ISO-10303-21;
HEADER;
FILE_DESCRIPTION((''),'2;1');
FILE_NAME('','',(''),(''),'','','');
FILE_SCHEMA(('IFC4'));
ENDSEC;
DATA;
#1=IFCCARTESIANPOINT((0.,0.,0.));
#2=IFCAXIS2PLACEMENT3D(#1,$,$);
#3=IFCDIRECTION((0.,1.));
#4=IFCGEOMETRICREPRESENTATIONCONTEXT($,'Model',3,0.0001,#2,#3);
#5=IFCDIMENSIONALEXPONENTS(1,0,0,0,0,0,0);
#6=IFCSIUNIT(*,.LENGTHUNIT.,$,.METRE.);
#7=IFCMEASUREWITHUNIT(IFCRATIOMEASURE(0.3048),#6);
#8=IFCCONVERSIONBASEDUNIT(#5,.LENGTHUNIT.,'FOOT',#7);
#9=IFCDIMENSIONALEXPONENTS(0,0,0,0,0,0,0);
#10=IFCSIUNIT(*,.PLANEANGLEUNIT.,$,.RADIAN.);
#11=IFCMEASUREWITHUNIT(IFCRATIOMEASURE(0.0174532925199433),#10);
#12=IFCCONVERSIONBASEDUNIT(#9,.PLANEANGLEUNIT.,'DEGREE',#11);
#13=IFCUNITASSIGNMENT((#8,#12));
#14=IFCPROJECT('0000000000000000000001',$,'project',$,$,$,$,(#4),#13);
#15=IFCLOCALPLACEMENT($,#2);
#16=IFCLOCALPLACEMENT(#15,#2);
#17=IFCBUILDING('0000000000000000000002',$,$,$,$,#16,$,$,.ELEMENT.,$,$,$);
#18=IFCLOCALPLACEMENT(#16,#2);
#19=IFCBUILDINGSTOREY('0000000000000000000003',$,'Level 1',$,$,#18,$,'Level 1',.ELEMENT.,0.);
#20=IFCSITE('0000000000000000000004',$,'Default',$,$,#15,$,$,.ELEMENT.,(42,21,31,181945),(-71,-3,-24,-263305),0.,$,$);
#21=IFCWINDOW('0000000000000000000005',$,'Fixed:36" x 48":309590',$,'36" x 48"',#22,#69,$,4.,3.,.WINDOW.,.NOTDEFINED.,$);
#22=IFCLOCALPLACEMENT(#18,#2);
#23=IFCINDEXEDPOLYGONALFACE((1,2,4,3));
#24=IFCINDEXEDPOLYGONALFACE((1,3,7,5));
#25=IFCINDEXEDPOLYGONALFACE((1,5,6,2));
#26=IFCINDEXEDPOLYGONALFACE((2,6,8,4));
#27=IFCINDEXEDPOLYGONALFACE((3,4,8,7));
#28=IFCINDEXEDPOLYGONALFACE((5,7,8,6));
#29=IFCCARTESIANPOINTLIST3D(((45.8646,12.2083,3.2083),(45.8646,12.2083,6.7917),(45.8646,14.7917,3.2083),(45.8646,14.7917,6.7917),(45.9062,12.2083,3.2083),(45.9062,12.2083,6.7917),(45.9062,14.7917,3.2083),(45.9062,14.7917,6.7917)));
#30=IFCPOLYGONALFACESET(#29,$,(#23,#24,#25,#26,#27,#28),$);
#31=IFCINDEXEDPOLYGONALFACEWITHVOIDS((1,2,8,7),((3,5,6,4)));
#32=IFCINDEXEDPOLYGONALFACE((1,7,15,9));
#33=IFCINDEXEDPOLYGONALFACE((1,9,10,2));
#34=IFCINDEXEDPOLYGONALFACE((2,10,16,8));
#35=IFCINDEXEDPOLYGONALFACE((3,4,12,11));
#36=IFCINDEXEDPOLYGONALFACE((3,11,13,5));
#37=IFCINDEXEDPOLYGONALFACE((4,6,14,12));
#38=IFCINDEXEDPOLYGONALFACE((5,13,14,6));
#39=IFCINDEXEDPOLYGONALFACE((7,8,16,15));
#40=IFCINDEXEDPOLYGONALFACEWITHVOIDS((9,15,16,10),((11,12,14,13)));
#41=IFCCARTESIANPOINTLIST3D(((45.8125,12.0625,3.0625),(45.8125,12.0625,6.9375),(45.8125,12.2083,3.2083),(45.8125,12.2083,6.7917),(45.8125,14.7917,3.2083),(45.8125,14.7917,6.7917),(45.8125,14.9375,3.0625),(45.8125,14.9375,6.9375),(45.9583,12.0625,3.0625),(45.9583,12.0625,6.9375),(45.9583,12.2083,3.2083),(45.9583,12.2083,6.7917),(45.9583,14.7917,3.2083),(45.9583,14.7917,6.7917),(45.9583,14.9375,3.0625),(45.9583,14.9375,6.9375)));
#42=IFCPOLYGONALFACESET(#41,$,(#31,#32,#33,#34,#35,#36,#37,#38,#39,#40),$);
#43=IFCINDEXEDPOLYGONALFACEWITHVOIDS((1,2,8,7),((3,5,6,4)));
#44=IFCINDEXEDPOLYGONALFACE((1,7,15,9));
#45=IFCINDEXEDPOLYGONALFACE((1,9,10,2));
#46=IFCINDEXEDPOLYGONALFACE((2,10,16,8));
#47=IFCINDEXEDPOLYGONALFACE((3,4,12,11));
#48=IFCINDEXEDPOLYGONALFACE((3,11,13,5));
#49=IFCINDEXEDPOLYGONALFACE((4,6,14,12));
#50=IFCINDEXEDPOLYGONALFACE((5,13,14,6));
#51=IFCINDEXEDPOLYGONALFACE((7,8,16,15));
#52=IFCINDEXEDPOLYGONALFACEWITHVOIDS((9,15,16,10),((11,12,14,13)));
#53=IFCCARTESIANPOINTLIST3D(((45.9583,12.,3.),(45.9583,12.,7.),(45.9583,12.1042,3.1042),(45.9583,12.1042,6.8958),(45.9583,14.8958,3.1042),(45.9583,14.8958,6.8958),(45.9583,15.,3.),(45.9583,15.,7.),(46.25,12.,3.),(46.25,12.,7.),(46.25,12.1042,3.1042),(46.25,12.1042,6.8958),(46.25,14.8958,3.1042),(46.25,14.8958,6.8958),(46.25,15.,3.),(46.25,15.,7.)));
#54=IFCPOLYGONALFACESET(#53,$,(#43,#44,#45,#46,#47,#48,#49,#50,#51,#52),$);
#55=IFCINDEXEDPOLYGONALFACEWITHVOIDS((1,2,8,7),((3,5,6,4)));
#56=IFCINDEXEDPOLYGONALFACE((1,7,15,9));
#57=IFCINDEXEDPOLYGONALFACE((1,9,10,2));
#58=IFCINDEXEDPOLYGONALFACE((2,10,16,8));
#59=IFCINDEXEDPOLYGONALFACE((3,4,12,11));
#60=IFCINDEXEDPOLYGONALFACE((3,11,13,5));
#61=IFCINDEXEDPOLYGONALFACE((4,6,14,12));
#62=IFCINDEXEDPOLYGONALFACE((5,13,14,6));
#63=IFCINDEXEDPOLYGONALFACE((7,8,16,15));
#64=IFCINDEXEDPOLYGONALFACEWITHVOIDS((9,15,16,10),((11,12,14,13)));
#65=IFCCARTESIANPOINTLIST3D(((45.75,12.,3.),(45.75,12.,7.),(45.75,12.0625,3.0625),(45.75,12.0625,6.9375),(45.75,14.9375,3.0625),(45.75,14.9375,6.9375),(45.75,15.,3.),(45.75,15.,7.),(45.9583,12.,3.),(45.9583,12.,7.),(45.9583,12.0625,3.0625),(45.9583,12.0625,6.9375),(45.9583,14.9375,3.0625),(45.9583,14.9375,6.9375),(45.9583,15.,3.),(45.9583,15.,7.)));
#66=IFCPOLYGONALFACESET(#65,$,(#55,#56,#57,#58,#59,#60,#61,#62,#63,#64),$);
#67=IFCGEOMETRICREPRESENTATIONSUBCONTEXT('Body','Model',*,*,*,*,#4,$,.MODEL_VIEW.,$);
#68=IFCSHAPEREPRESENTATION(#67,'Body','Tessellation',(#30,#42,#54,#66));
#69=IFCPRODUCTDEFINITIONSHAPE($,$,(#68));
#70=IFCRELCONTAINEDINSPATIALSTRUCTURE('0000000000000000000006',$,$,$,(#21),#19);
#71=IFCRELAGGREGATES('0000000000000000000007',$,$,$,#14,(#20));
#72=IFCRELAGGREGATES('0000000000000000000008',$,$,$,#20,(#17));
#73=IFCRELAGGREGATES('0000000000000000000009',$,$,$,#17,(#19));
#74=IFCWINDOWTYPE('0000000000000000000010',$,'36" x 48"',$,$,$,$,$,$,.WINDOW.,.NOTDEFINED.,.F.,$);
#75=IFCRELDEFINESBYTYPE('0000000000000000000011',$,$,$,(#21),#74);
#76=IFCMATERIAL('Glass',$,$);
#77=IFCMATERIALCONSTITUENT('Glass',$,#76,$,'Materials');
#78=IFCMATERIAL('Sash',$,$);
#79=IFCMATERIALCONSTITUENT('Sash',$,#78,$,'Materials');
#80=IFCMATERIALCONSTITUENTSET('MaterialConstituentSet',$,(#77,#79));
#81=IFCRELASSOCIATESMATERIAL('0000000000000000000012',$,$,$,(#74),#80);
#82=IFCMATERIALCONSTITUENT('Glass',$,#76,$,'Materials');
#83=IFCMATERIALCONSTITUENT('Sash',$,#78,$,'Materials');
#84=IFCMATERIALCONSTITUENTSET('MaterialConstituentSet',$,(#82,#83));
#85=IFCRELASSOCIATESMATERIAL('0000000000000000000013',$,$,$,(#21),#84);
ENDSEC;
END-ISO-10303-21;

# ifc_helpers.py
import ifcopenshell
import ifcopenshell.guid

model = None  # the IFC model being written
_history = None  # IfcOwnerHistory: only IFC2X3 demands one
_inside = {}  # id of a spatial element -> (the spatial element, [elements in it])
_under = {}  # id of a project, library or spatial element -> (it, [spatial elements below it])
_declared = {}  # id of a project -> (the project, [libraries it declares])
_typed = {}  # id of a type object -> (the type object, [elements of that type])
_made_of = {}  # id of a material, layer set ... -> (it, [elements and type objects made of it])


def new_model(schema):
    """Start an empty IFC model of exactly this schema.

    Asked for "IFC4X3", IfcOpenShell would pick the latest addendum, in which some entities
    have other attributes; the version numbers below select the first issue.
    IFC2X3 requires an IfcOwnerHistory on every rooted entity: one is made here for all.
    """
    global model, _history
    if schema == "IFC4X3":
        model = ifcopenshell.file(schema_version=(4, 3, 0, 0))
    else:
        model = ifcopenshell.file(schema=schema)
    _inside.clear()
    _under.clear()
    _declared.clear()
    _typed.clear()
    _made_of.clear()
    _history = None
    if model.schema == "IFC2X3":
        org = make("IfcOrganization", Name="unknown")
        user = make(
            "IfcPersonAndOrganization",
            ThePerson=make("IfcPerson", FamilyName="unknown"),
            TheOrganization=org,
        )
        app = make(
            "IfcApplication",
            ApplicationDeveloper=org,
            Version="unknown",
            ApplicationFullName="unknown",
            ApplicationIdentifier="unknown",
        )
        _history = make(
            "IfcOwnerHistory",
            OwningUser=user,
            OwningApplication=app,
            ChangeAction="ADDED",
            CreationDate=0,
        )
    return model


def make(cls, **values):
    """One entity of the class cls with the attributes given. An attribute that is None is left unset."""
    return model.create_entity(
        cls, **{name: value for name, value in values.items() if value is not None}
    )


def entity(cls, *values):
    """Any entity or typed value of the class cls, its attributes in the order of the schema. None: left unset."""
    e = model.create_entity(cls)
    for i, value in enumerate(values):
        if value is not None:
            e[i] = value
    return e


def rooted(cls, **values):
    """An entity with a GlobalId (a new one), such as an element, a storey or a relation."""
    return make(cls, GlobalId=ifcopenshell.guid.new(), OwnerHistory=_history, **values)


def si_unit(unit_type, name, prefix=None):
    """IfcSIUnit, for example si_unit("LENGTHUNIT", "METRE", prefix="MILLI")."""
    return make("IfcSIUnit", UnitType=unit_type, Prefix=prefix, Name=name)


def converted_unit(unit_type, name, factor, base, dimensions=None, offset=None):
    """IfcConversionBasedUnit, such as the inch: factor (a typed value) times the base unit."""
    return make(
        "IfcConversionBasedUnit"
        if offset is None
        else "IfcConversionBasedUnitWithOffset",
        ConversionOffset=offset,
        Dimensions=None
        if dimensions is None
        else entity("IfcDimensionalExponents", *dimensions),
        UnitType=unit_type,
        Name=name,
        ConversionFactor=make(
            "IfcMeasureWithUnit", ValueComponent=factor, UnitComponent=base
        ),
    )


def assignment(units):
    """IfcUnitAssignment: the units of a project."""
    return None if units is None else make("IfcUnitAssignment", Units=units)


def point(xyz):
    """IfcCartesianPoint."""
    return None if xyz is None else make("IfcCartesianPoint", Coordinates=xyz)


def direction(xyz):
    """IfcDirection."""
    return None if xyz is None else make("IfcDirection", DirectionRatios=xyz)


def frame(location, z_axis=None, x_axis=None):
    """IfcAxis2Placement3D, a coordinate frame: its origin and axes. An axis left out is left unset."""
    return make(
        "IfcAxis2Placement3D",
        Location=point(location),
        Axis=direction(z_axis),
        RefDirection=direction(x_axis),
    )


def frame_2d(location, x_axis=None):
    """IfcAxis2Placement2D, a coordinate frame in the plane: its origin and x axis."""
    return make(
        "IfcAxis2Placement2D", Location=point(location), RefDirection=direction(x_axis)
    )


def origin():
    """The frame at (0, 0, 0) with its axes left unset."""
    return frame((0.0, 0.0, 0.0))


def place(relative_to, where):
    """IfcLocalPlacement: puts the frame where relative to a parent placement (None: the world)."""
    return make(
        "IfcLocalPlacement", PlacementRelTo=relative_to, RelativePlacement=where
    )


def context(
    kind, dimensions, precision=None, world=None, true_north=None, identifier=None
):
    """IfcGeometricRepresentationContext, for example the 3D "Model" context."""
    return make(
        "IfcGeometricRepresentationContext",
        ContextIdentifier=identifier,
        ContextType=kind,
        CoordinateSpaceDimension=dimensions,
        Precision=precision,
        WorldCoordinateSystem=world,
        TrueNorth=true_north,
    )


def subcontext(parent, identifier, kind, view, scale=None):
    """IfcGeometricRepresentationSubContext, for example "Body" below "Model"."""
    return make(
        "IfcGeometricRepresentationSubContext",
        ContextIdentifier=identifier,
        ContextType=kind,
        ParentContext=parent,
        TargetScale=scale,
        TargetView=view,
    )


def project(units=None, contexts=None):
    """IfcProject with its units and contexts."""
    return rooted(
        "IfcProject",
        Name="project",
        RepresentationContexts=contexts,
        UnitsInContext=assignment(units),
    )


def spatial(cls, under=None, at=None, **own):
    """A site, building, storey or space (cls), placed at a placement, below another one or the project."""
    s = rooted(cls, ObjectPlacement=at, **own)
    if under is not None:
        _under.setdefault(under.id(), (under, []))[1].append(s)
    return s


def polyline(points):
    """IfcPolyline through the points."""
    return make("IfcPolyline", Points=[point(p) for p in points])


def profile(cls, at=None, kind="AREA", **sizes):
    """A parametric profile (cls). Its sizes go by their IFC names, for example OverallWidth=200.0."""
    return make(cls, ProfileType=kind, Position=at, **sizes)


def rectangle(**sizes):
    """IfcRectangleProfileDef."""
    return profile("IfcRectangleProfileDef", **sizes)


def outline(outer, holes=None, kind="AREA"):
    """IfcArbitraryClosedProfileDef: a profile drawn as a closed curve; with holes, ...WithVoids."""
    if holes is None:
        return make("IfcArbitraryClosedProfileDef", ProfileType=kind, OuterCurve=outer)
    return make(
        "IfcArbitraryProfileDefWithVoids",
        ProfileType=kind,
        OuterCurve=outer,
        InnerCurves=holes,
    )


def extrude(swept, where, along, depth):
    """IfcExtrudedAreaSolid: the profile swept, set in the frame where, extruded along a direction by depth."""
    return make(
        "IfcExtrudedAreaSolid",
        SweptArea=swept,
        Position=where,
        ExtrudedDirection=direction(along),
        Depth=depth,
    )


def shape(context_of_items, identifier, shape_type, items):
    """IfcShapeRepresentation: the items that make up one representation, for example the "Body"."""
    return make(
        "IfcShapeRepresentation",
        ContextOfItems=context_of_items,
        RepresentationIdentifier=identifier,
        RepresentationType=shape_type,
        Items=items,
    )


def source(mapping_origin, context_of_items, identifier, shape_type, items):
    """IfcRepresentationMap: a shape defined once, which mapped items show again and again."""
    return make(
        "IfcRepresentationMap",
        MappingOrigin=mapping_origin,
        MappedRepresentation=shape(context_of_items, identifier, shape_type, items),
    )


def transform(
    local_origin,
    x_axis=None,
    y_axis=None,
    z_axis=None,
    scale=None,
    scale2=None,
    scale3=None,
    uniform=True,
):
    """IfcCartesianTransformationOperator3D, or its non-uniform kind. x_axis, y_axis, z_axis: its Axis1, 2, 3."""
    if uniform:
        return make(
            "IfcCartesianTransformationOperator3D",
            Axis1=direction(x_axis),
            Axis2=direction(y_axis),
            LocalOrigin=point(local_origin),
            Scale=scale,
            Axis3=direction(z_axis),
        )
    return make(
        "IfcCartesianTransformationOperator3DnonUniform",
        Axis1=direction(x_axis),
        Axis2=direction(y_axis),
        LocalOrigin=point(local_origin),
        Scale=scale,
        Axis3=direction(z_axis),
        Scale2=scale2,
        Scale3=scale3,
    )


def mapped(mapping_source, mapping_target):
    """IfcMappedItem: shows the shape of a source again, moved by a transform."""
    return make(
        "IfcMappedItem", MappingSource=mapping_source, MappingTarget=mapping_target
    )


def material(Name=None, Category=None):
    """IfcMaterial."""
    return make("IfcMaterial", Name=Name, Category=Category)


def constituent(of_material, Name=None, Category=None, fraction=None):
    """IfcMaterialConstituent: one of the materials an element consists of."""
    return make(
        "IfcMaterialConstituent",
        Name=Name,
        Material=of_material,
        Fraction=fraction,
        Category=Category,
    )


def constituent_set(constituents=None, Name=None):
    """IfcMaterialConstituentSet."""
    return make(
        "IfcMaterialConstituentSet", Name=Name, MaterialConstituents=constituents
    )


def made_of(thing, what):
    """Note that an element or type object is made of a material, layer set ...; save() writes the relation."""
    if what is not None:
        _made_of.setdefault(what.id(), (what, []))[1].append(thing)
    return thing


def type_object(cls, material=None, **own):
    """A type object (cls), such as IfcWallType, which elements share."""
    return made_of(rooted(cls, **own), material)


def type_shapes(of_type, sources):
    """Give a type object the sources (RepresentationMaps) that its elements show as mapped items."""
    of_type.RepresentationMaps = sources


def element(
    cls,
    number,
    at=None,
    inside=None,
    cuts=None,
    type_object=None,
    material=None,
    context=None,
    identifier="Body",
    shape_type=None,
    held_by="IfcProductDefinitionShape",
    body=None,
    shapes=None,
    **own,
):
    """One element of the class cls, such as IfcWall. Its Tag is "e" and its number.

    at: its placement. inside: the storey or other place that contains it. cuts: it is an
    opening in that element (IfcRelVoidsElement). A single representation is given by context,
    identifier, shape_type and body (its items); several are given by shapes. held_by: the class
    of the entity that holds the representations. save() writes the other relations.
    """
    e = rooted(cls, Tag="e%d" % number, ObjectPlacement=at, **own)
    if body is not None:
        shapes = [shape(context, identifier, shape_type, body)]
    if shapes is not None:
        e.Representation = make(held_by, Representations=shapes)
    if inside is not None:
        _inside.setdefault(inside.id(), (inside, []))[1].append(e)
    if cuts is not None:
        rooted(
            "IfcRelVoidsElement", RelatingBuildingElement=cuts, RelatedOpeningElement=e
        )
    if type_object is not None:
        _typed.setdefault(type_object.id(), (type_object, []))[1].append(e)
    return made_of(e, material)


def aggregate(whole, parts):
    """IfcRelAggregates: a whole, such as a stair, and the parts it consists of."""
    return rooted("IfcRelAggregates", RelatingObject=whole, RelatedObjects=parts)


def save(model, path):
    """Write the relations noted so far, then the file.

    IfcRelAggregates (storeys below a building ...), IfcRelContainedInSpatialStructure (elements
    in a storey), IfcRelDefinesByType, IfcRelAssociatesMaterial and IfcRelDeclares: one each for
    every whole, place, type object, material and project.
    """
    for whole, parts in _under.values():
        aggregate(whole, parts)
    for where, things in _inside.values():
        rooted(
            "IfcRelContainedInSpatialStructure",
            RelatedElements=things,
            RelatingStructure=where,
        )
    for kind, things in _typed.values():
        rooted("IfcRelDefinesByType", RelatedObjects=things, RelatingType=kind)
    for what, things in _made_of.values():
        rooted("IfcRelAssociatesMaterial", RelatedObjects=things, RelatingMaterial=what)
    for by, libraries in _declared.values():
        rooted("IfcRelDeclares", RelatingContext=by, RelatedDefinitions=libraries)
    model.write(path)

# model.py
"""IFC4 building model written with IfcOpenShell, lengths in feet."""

from ifc_helpers import new_model, entity, si_unit, converted_unit, direction, frame, frame_2d, origin, place, context, subcontext, project, spatial, polyline, rectangle, outline, extrude, source, transform, mapped, material, constituent, constituent_set, type_object, type_shapes, element, save


model = new_model("IFC4")

# Units and contexts
model_context = context("Model", 3, precision=0.0001, world=origin(), true_north=direction((0.0, 1.0)))
body_context = subcontext(model_context, "Body", "Model", "MODEL_VIEW")
ifc_project = project(units=[converted_unit("LENGTHUNIT", "FOOT", entity("IfcRatioMeasure", 0.3048), si_unit("LENGTHUNIT", "METRE"), dimensions=[1, 0, 0, 0, 0, 0, 0]), converted_unit("PLANEANGLEUNIT", "DEGREE", entity("IfcRatioMeasure", 0.0174532925199433), si_unit("PLANEANGLEUNIT", "RADIAN"), dimensions=[0, 0, 0, 0, 0, 0, 0])], contexts=[model_context])

# Site, building, storey
site_placement = place(None, origin())
site = spatial("IfcSite", under=ifc_project, at=site_placement, Name="Default", CompositionType="ELEMENT", RefLatitude=(42, 21, 31, 181945), RefLongitude=(-71, -3, -24, -263305), RefElevation=0.0)
building_placement = place(site_placement, origin())
building = spatial("IfcBuilding", under=site, at=building_placement, CompositionType="ELEMENT")
storey_placement = place(building_placement, origin())
storey = spatial("IfcBuildingStorey", under=building, at=storey_placement, Name="Level 1", LongName="Level 1", CompositionType="ELEMENT", Elevation=0.0)

# Shared definitions
placement_1 = place(storey_placement, frame((46.0, 46.25, 0.0), z_axis=(0.0, 0.0, 1.0), x_axis=(0.0, -1.0, 0.0)))

# Window
ifc_material_1 = material(Name="Glass")
ifc_constituent_1 = constituent(ifc_material_1, Name="Glass", Category="Materials")
ifc_material_2 = material(Name="Sash")
ifc_constituent_2 = constituent(ifc_material_2, Name="Sash", Category="Materials")
ifc_constituent_set_1 = constituent_set(constituents=[ifc_constituent_1, ifc_constituent_2], Name="MaterialConstituentSet")
ifc_constituent_3 = constituent(ifc_material_1, Name="Glass", Category="Materials")
ifc_constituent_4 = constituent(ifc_material_2, Name="Sash", Category="Materials")
ifc_constituent_set_2 = constituent_set(constituents=[ifc_constituent_3, ifc_constituent_4], Name="MaterialConstituentSet")
window_type = type_object("IfcWindowType", Name="36\" x 48\"", ParameterTakesPrecedence=False, PartitioningType="NOTDEFINED", PredefinedType="WINDOW", material=ifc_constituent_set_2)
shared_shape = source(origin(), body_context, "Body", "SweptSolid", [
    extrude(rectangle(XDim=0.0417, YDim=2.5833, at=frame_2d((0.0, 0.0), x_axis=(1.0, 0.0))), frame((1.5, 0.3646, 0.2083), z_axis=(0.0, 0.0, 1.0), x_axis=(0.0, 1.0, 0.0)), (0.0, 0.0, 1.0), 3.5833),
    extrude(outline(polyline([(-1.4375, -1.9375), (1.4375, -1.9375), (1.4375, 1.9375), (-1.4375, 1.9375), (-1.4375, -1.9375)]), holes=[polyline([(-1.2917, -1.7917), (-1.2917, 1.7917), (1.2917, 1.7917), (1.2917, -1.7917), (-1.2917, -1.7917)])]), frame((1.5, 0.2917, 2.0), z_axis=(0.0, 1.0, 0.0), x_axis=(1.0, 0.0, 0.0)), (0.0, 0.0, 1.0), 0.1458),
    extrude(outline(polyline([(-1.5, -2.0), (1.5, -2.0), (1.5, 2.0), (-1.5, 2.0), (-1.5, -2.0)]), holes=[polyline([(-1.3958, -1.8958), (-1.3958, 1.8958), (1.3958, 1.8958), (1.3958, -1.8958), (-1.3958, -1.8958)])]), frame((1.5, 0.0, 2.0), z_axis=(0.0, 1.0, 0.0), x_axis=(1.0, 0.0, 0.0)), (0.0, 0.0, 1.0), 0.2917),
    extrude(outline(polyline([(-2.0, -1.5), (2.0, -1.5), (2.0, 1.5), (-2.0, 1.5), (-2.0, -1.5)]), holes=[polyline([(-1.9375, -1.4375), (-1.9375, 1.4375), (1.9375, 1.4375), (1.9375, -1.4375), (-1.9375, -1.4375)])]), frame((1.5, 0.2917, 2.0), z_axis=(0.0, 1.0, 0.0), x_axis=(0.0, 0.0, -1.0)), (0.0, 0.0, 1.0), 0.2083),
])
type_shapes(window_type, [shared_shape])
placement_2 = place(placement_1, frame((34.25, 0.25, 3.0)))
window_placement = place(placement_2, frame((0.0, 0.0, 0.0), z_axis=(0.0, 0.0, 1.0), x_axis=(-1.0, 0.0, 0.0)))
element("IfcWindow", 1, at=window_placement, inside=storey, type_object=window_type, material=ifc_constituent_set_1, Name="Fixed:36\" x 48\":309590", ObjectType="36\" x 48\"", OverallHeight=4.0, OverallWidth=3.0, PartitioningType="NOTDEFINED", PredefinedType="WINDOW", context=body_context, shape_type="MappedRepresentation", body=[
    mapped(shared_shape, transform((0.0, 0.0, 0.0), scale=1.0)),
])

save(model, "model.ifc")
